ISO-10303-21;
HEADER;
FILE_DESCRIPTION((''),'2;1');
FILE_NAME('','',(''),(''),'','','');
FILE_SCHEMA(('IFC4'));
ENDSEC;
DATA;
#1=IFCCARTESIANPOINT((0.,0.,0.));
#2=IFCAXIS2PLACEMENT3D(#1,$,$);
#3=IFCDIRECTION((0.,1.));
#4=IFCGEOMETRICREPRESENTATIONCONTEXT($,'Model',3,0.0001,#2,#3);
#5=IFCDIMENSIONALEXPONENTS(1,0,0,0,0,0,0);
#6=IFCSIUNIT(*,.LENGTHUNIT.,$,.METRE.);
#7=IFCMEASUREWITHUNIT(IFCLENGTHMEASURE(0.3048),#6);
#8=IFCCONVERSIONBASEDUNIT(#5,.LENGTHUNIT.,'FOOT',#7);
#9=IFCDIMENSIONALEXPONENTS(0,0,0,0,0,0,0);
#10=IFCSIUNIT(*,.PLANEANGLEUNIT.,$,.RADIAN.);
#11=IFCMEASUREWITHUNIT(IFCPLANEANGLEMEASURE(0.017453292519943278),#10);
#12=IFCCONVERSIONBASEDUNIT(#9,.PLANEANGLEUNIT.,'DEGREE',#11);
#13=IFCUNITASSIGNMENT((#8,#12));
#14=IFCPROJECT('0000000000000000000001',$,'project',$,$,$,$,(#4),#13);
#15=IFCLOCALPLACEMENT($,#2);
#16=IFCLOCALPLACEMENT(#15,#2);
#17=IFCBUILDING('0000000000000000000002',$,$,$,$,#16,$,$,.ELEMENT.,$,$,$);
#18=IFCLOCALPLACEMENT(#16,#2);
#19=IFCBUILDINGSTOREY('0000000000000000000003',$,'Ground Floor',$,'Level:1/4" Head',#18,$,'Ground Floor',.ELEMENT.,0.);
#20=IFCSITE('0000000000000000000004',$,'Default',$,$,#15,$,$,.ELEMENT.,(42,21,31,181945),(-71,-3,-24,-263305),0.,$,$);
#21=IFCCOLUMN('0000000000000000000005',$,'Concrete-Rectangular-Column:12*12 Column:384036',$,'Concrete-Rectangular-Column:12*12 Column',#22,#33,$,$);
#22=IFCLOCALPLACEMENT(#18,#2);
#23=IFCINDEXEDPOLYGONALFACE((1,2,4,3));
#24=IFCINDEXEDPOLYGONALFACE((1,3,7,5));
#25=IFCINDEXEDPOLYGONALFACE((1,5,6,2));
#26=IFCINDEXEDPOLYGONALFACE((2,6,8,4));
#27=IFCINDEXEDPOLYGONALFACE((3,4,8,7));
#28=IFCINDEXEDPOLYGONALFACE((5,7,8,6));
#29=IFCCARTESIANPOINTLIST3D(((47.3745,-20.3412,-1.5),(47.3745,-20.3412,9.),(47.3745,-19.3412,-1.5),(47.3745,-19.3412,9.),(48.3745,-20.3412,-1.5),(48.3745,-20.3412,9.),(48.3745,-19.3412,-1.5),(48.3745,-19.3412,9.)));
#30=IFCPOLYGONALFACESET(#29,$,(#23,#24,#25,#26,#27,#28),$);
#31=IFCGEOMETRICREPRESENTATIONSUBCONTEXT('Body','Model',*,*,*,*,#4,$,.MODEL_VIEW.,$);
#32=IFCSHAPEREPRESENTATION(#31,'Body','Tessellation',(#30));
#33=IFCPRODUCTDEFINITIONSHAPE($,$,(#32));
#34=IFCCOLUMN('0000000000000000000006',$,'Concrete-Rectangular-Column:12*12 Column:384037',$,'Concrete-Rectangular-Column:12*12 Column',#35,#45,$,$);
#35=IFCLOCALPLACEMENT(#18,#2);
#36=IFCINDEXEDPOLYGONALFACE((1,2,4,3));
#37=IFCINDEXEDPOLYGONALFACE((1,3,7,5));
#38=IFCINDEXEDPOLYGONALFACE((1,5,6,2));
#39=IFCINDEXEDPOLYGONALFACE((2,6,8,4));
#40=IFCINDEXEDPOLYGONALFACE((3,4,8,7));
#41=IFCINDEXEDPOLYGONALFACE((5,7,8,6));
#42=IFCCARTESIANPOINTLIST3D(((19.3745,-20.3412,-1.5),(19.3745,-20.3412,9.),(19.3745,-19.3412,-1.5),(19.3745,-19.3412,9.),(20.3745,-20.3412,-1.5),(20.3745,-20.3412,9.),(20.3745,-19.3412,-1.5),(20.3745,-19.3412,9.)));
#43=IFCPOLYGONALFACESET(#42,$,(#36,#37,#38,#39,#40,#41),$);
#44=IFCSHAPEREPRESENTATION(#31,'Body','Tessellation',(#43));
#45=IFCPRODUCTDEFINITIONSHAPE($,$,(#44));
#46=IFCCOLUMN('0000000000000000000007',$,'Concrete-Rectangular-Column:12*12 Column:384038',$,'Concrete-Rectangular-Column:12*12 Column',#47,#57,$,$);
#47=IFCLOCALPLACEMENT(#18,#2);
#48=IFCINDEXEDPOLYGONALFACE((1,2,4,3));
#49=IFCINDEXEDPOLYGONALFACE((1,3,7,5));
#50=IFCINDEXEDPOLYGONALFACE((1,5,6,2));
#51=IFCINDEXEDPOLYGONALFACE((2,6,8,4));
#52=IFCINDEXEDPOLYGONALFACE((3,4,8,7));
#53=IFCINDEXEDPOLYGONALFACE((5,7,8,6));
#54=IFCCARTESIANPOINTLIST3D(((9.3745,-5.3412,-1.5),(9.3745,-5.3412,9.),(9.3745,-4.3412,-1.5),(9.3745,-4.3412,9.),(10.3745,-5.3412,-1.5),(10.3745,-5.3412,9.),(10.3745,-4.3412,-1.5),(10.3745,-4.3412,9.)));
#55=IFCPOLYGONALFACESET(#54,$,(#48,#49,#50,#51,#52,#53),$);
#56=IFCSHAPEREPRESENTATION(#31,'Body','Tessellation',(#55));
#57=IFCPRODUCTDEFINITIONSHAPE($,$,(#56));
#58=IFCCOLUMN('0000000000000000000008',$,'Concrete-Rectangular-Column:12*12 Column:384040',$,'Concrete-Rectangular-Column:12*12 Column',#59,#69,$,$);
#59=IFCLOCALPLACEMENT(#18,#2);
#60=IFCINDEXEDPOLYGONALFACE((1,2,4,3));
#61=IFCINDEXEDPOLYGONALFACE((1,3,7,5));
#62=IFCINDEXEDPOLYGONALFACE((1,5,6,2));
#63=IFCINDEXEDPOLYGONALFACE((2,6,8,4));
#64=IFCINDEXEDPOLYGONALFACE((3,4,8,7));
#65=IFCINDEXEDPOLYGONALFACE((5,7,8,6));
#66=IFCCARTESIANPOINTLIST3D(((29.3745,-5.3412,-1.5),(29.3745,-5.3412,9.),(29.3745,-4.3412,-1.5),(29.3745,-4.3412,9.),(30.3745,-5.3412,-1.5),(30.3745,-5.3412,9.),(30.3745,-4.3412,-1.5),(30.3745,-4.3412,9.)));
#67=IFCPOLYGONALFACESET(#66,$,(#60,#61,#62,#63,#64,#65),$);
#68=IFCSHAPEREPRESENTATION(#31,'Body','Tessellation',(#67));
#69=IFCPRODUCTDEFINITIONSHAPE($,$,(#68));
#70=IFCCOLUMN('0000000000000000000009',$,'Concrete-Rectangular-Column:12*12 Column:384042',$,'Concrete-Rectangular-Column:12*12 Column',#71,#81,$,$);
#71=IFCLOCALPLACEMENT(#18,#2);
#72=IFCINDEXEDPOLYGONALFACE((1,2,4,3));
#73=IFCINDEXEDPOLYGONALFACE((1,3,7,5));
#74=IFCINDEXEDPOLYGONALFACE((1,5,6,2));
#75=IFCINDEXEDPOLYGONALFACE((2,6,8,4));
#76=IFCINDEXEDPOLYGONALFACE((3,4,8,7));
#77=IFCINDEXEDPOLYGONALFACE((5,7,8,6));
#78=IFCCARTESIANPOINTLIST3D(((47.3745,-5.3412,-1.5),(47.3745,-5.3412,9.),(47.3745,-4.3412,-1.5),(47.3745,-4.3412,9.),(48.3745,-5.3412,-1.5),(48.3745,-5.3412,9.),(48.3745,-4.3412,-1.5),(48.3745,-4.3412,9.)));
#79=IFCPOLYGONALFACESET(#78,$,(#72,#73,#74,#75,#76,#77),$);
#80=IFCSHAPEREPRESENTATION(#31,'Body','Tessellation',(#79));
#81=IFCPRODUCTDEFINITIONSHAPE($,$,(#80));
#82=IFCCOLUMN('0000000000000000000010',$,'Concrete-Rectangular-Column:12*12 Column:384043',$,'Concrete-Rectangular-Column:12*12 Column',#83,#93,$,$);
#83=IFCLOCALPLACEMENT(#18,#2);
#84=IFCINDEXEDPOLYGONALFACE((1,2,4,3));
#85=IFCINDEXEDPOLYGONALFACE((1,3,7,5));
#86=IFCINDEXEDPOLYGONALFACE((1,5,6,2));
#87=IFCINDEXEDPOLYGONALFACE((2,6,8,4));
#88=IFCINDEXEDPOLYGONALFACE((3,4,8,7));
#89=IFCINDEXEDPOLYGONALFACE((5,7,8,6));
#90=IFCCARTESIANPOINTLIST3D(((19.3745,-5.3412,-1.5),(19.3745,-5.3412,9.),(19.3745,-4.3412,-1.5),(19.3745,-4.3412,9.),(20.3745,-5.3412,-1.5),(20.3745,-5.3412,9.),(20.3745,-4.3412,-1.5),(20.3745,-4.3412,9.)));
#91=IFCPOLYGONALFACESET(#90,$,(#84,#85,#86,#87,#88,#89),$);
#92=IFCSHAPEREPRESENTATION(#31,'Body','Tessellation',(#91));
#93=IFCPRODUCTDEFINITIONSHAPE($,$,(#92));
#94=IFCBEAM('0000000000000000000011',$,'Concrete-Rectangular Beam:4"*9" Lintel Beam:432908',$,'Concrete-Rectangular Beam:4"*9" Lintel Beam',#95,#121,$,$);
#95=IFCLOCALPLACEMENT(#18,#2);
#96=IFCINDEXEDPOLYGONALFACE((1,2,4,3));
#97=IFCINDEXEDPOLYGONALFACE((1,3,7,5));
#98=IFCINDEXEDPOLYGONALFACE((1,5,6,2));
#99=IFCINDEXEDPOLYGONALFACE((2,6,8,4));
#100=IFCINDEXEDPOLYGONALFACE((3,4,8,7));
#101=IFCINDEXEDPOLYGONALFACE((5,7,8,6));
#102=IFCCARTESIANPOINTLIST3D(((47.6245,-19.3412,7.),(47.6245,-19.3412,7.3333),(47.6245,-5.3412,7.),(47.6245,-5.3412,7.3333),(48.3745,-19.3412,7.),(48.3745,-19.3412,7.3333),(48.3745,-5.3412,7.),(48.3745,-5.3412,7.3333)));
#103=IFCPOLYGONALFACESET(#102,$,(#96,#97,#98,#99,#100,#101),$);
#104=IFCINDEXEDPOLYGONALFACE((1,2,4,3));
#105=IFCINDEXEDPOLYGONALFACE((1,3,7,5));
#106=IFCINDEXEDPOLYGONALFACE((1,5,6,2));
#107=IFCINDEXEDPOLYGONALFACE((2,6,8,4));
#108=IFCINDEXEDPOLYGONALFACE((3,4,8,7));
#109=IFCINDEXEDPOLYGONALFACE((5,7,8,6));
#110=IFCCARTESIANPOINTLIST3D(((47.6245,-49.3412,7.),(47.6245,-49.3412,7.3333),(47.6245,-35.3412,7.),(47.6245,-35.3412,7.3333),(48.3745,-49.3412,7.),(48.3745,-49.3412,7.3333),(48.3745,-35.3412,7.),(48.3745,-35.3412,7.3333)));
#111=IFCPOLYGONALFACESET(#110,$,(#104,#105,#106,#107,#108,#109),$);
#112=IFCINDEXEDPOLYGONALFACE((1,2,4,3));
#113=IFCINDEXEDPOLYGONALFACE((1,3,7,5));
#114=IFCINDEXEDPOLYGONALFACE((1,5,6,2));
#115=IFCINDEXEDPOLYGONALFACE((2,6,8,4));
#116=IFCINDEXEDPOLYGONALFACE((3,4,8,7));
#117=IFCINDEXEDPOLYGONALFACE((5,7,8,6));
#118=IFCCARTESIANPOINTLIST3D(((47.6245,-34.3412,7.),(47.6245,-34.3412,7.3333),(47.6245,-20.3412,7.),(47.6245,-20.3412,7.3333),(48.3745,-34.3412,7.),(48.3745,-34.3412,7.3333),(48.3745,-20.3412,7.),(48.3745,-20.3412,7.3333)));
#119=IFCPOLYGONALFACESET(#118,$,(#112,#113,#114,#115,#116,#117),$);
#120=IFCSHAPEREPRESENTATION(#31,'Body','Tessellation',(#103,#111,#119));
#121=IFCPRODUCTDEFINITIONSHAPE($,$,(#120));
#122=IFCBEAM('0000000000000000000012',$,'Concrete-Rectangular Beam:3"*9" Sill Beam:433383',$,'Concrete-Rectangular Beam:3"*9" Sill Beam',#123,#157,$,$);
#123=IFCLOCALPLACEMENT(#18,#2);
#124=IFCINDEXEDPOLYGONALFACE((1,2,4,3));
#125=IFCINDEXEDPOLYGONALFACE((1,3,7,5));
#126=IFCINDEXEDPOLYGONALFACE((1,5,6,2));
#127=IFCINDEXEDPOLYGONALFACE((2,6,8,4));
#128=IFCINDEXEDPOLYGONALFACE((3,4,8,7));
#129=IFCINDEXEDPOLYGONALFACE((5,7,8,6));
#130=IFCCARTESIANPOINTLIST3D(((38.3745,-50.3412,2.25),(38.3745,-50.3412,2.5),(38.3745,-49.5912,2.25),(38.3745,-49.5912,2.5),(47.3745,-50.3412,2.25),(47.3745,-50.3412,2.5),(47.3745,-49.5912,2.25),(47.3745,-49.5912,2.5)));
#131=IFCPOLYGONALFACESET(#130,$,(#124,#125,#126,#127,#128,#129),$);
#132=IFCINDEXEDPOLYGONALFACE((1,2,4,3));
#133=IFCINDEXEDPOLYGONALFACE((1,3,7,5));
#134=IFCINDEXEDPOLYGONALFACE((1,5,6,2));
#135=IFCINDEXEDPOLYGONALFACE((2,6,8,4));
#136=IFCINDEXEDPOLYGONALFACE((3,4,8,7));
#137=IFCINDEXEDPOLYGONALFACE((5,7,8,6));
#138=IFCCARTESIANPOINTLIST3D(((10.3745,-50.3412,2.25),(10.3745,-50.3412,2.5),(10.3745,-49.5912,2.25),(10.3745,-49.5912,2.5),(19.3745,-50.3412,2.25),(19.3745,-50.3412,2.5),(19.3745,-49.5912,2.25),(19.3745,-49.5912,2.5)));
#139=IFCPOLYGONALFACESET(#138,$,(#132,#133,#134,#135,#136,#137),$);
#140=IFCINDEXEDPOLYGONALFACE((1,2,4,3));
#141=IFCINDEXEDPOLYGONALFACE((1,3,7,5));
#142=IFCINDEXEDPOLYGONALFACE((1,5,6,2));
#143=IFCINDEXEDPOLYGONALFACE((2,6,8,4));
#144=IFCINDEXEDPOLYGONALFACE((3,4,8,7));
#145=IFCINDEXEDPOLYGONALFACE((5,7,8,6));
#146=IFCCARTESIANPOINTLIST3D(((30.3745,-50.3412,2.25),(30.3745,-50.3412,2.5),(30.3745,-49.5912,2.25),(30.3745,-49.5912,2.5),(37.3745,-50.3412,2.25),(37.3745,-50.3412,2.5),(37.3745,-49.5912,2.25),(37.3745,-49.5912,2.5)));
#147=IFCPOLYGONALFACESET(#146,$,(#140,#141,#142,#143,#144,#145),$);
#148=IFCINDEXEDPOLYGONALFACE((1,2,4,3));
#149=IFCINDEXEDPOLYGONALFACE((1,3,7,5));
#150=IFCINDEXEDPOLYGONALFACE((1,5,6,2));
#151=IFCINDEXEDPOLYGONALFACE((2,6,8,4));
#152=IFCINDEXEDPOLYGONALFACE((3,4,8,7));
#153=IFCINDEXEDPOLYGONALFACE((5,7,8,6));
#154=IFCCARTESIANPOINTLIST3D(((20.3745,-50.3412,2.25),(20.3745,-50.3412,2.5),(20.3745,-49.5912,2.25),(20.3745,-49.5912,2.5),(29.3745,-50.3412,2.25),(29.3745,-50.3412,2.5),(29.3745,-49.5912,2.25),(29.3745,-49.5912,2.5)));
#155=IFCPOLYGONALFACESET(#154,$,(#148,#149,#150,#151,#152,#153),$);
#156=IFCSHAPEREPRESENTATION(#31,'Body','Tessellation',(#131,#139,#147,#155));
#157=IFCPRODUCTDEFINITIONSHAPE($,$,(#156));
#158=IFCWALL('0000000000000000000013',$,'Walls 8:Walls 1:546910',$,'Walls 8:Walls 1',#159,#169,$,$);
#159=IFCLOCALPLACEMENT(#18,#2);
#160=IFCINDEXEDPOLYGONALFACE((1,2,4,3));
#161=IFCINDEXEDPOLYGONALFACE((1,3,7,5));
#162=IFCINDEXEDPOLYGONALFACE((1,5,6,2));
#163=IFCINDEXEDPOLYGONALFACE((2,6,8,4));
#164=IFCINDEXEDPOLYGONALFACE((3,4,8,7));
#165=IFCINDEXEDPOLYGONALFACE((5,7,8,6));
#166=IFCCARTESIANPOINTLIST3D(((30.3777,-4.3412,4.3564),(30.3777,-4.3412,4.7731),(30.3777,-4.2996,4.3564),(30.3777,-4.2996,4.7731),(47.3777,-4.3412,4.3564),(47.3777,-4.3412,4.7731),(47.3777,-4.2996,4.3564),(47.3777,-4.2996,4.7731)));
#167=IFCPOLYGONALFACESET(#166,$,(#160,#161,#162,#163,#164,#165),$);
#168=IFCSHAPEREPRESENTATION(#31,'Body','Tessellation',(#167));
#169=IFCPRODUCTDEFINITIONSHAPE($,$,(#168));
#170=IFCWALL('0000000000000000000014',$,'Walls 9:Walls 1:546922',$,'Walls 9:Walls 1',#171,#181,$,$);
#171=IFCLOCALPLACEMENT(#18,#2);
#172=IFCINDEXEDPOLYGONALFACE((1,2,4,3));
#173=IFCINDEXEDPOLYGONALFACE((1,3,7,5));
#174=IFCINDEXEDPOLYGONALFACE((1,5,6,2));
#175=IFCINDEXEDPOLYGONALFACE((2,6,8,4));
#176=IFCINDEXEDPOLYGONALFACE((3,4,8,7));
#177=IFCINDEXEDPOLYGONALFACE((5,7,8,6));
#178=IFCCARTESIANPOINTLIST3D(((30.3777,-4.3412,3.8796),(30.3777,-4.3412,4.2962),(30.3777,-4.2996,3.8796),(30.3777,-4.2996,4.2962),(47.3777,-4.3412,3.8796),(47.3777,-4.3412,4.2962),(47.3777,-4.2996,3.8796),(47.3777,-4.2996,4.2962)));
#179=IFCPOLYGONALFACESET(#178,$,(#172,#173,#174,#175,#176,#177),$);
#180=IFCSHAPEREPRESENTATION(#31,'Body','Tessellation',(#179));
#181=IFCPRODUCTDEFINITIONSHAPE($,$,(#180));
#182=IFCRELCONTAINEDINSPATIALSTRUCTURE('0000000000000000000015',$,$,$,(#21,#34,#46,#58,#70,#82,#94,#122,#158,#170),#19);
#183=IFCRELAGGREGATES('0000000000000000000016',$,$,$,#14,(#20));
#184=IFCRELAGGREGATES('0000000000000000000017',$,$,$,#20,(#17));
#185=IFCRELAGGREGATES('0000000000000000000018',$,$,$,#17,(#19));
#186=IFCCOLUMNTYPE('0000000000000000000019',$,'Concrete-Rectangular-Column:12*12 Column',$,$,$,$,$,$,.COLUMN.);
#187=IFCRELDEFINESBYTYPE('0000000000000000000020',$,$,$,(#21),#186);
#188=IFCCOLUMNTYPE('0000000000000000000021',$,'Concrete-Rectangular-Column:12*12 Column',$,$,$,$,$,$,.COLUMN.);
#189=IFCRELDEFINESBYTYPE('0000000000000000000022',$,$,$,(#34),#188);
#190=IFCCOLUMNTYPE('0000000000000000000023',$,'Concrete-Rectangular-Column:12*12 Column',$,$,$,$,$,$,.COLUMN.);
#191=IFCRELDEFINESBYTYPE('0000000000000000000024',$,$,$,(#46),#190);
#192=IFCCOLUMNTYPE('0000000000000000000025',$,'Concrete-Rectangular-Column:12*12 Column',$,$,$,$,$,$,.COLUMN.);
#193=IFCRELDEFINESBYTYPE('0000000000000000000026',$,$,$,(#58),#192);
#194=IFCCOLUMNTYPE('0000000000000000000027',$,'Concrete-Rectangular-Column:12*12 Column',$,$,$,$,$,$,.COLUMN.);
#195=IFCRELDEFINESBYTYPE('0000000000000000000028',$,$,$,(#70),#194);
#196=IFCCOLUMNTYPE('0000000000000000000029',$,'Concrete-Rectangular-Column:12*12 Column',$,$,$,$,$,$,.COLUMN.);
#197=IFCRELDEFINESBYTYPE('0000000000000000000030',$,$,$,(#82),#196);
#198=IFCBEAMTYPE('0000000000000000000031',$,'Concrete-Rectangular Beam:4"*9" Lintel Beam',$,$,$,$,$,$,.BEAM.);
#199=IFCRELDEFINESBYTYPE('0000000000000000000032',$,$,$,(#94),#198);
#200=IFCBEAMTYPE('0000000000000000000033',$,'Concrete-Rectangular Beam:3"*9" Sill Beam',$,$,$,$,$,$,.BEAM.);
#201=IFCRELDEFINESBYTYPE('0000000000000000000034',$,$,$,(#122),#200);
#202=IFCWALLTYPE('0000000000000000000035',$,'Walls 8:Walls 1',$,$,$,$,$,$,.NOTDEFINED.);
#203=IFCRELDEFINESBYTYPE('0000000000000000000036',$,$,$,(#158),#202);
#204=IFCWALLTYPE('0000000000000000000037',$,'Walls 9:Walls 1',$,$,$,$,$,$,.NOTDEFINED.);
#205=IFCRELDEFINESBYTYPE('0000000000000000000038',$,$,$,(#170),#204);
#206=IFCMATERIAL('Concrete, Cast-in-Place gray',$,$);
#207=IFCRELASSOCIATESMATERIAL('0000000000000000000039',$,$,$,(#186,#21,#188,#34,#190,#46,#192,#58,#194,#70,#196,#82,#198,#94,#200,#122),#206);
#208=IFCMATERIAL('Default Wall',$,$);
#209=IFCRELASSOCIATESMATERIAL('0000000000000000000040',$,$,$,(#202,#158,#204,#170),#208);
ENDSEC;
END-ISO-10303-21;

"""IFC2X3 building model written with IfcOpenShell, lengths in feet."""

from ifc_helpers import new_model, entity, si_unit, converted_unit, direction, frame, frame_2d, origin, origin_2d_with_axis, place, context, subcontext, project, spatial, rectangle, extrude, source, transform, mapped, material, type_object, type_shapes, element, save


model = new_model("IFC2X3")

# Units and contexts
model_context = context("Model", 3, precision=0.0001, world=origin(), true_north=direction((0.0, 1.0)))
body_context = subcontext(model_context, "Body", "Model", "MODEL_VIEW")
ifc_project = project(units=[converted_unit("LENGTHUNIT", "FOOT", entity("IfcLengthMeasure", 0.3048), si_unit("LENGTHUNIT", "METRE"), dimensions=[1, 0, 0, 0, 0, 0, 0]), converted_unit("PLANEANGLEUNIT", "DEGREE", entity("IfcPlaneAngleMeasure", 0.017453292519943278), si_unit("PLANEANGLEUNIT", "RADIAN"), dimensions=[0, 0, 0, 0, 0, 0, 0])], contexts=[model_context])

# Site, building, storey
site_placement = place(None, origin())
site = spatial("IfcSite", under=ifc_project, at=site_placement, Name="Default", CompositionType="ELEMENT", RefLatitude=(42, 21, 31, 181945), RefLongitude=(-71, -3, -24, -263305), RefElevation=0.0)
building_placement = place(site_placement, origin())
building = spatial("IfcBuilding", under=site, at=building_placement, CompositionType="ELEMENT")
storey_placement = place(building_placement, origin())
storey = spatial("IfcBuildingStorey", under=building, at=storey_placement, Name="Ground Floor", ObjectType="Level:1/4\" Head", LongName="Ground Floor", CompositionType="ELEMENT", Elevation=0.0)

# Columns
ifc_material_1 = material(Name="Concrete, Cast-in-Place gray")
column_type_1 = type_object("IfcColumnType", Name="Concrete-Rectangular-Column:12*12 Column", PredefinedType="COLUMN", material=ifc_material_1)
shared_shape_1 = source(origin(), body_context, "Body", "SweptSolid", [
    extrude(rectangle(XDim=1.0, YDim=1.0, at=frame_2d((0.0, 0.0), x_axis=(1.0, 0.0))), frame((47.8745, -19.8412, -1.5), z_axis=(0.0, 0.0, 1.0), x_axis=(-1.0, 0.0, 0.0)), (0.0, 0.0, 1.0), 10.5),
])
type_shapes(column_type_1, [shared_shape_1])
column_1_placement = place(storey_placement, origin())
element("IfcColumn", 1, at=column_1_placement, inside=storey, type_object=column_type_1, material=ifc_material_1, Name="Concrete-Rectangular-Column:12*12 Column:384036", ObjectType="Concrete-Rectangular-Column:12*12 Column", context=body_context, shape_type="MappedRepresentation", body=[
    mapped(shared_shape_1, transform((0.0, 0.0, 0.0), scale=1.0)),
])
column_type_2 = type_object("IfcColumnType", Name="Concrete-Rectangular-Column:12*12 Column", PredefinedType="COLUMN", material=ifc_material_1)
shared_shape_2 = source(origin(), body_context, "Body", "SweptSolid", [
    extrude(rectangle(XDim=1.0, YDim=1.0, at=frame_2d((0.0, 0.0), x_axis=(1.0, 0.0))), frame((19.8745, -19.8412, -1.5), z_axis=(0.0, 0.0, 1.0), x_axis=(-1.0, 0.0, 0.0)), (0.0, 0.0, 1.0), 10.5),
])
type_shapes(column_type_2, [shared_shape_2])
column_2_placement = place(storey_placement, origin())
element("IfcColumn", 2, at=column_2_placement, inside=storey, type_object=column_type_2, material=ifc_material_1, Name="Concrete-Rectangular-Column:12*12 Column:384037", ObjectType="Concrete-Rectangular-Column:12*12 Column", context=body_context, shape_type="MappedRepresentation", body=[
    mapped(shared_shape_2, transform((0.0, 0.0, 0.0), scale=1.0)),
])
column_type_3 = type_object("IfcColumnType", Name="Concrete-Rectangular-Column:12*12 Column", PredefinedType="COLUMN", material=ifc_material_1)
shared_shape_3 = source(origin(), body_context, "Body", "SweptSolid", [
    extrude(rectangle(XDim=1.0, YDim=1.0, at=origin_2d_with_axis()), frame((9.8745, -4.8412, -1.5), z_axis=(0.0, 0.0, 1.0), x_axis=(-1.0, 0.0, 0.0)), (0.0, 0.0, 1.0), 10.5),
])
type_shapes(column_type_3, [shared_shape_3])
column_3_placement = place(storey_placement, origin())
element("IfcColumn", 3, at=column_3_placement, inside=storey, type_object=column_type_3, material=ifc_material_1, Name="Concrete-Rectangular-Column:12*12 Column:384038", ObjectType="Concrete-Rectangular-Column:12*12 Column", context=body_context, shape_type="MappedRepresentation", body=[
    mapped(shared_shape_3, transform((0.0, 0.0, 0.0), scale=1.0)),
])
column_type_4 = type_object("IfcColumnType", Name="Concrete-Rectangular-Column:12*12 Column", PredefinedType="COLUMN", material=ifc_material_1)
shared_shape_4 = source(origin(), body_context, "Body", "SweptSolid", [
    extrude(rectangle(XDim=1.0, YDim=1.0, at=frame_2d((0.0, 0.0), x_axis=(1.0, 0.0))), frame((29.8745, -4.8412, -1.5), z_axis=(0.0, 0.0, 1.0), x_axis=(-1.0, 0.0, 0.0)), (0.0, 0.0, 1.0), 10.5),
])
type_shapes(column_type_4, [shared_shape_4])
column_4_placement = place(storey_placement, origin())
element("IfcColumn", 4, at=column_4_placement, inside=storey, type_object=column_type_4, material=ifc_material_1, Name="Concrete-Rectangular-Column:12*12 Column:384040", ObjectType="Concrete-Rectangular-Column:12*12 Column", context=body_context, shape_type="MappedRepresentation", body=[
    mapped(shared_shape_4, transform((0.0, 0.0, 0.0), scale=1.0)),
])
column_type_5 = type_object("IfcColumnType", Name="Concrete-Rectangular-Column:12*12 Column", PredefinedType="COLUMN", material=ifc_material_1)
shared_shape_5 = source(origin(), body_context, "Body", "SweptSolid", [
    extrude(rectangle(XDim=1.0, YDim=1.0, at=frame_2d((0.0, 0.0), x_axis=(1.0, 0.0))), frame((47.8745, -4.8412, -1.5), z_axis=(0.0, 0.0, 1.0), x_axis=(-1.0, 0.0, 0.0)), (0.0, 0.0, 1.0), 10.5),
])
type_shapes(column_type_5, [shared_shape_5])
column_5_placement = place(storey_placement, origin())
element("IfcColumn", 5, at=column_5_placement, inside=storey, type_object=column_type_5, material=ifc_material_1, Name="Concrete-Rectangular-Column:12*12 Column:384042", ObjectType="Concrete-Rectangular-Column:12*12 Column", context=body_context, shape_type="MappedRepresentation", body=[
    mapped(shared_shape_5, transform((0.0, 0.0, 0.0), scale=1.0)),
])
column_type_6 = type_object("IfcColumnType", Name="Concrete-Rectangular-Column:12*12 Column", PredefinedType="COLUMN", material=ifc_material_1)
shared_shape_6 = source(origin(), body_context, "Body", "SweptSolid", [
    extrude(rectangle(XDim=1.0, YDim=1.0, at=frame_2d((0.0, 0.0), x_axis=(1.0, 0.0))), frame((19.8745, -4.8412, -1.5), z_axis=(0.0, 0.0, 1.0), x_axis=(-1.0, 0.0, 0.0)), (0.0, 0.0, 1.0), 10.5),
])
type_shapes(column_type_6, [shared_shape_6])
column_6_placement = place(storey_placement, origin())
element("IfcColumn", 6, at=column_6_placement, inside=storey, type_object=column_type_6, material=ifc_material_1, Name="Concrete-Rectangular-Column:12*12 Column:384043", ObjectType="Concrete-Rectangular-Column:12*12 Column", context=body_context, shape_type="MappedRepresentation", body=[
    mapped(shared_shape_6, transform((0.0, 0.0, 0.0), scale=1.0)),
])

# Beams
beam_type_1 = type_object("IfcBeamType", Name="Concrete-Rectangular Beam:4\"*9\" Lintel Beam", PredefinedType="BEAM", material=ifc_material_1)
shared_shape_7 = source(origin(), body_context, "Body", "SweptSolid", [
    extrude(rectangle(XDim=0.3333, YDim=0.75, at=frame_2d((0.0, 0.0), x_axis=(0.0, 1.0))), frame((47.9995, -19.3412, 7.1667), z_axis=(0.0, 1.0, 0.0), x_axis=(-1.0, 0.0, 0.0)), (0.0, 0.0, 1.0), 14.0),
    extrude(rectangle(XDim=0.3333, YDim=0.75, at=frame_2d((0.0, 0.0), x_axis=(0.0, 1.0))), frame((47.9995, -49.3412, 7.1667), z_axis=(0.0, 1.0, 0.0), x_axis=(-1.0, 0.0, 0.0)), (0.0, 0.0, 1.0), 14.0),
    extrude(rectangle(XDim=0.3333, YDim=0.75, at=frame_2d((0.0, 0.0), x_axis=(0.0, 1.0))), frame((47.9995, -34.3412, 7.1667), z_axis=(0.0, 1.0, 0.0), x_axis=(-1.0, 0.0, 0.0)), (0.0, 0.0, 1.0), 14.0),
])
type_shapes(beam_type_1, [shared_shape_7])
beam_1_placement = place(storey_placement, origin())
element("IfcBeam", 7, at=beam_1_placement, inside=storey, type_object=beam_type_1, material=ifc_material_1, Name="Concrete-Rectangular Beam:4\"*9\" Lintel Beam:432908", ObjectType="Concrete-Rectangular Beam:4\"*9\" Lintel Beam", context=body_context, shape_type="MappedRepresentation", body=[
    mapped(shared_shape_7, transform((0.0, 0.0, 0.0), scale=1.0)),
])
beam_type_2 = type_object("IfcBeamType", Name="Concrete-Rectangular Beam:3\"*9\" Sill Beam", PredefinedType="BEAM", material=ifc_material_1)
shared_shape_8 = source(origin(), body_context, "Body", "SweptSolid", [
    extrude(rectangle(XDim=0.25, YDim=0.75, at=frame_2d((0.0, 0.0), x_axis=(1.0, 0.0))), frame((38.3745, -49.9662, 2.375), z_axis=(1.0, 0.0, 0.0), x_axis=(0.0, 0.0, -1.0)), (0.0, 0.0, 1.0), 9.0),
    extrude(rectangle(XDim=0.25, YDim=0.75, at=frame_2d((0.0, 0.0), x_axis=(1.0, 0.0))), frame((10.3745, -49.9662, 2.375), z_axis=(1.0, 0.0, 0.0), x_axis=(0.0, 0.0, -1.0)), (0.0, 0.0, 1.0), 9.0),
    extrude(rectangle(XDim=0.25, YDim=0.75, at=frame_2d((0.0, 0.0), x_axis=(1.0, 0.0))), frame((30.3745, -49.9662, 2.375), z_axis=(1.0, 0.0, 0.0), x_axis=(0.0, 0.0, -1.0)), (0.0, 0.0, 1.0), 7.0),
    extrude(rectangle(XDim=0.25, YDim=0.75, at=frame_2d((0.0, 0.0), x_axis=(1.0, 0.0))), frame((20.3745, -49.9662, 2.375), z_axis=(1.0, 0.0, 0.0), x_axis=(0.0, 0.0, -1.0)), (0.0, 0.0, 1.0), 9.0),
])
type_shapes(beam_type_2, [shared_shape_8])
beam_2_placement = place(storey_placement, origin())
element("IfcBeam", 8, at=beam_2_placement, inside=storey, type_object=beam_type_2, material=ifc_material_1, Name="Concrete-Rectangular Beam:3\"*9\" Sill Beam:433383", ObjectType="Concrete-Rectangular Beam:3\"*9\" Sill Beam", context=body_context, shape_type="MappedRepresentation", body=[
    mapped(shared_shape_8, transform((0.0, 0.0, 0.0), scale=1.0)),
])

# Walls
ifc_material_2 = material(Name="Default Wall")
wall_type_1 = type_object("IfcWallType", Name="Walls 8:Walls 1", PredefinedType="NOTDEFINED", material=ifc_material_2)
wall_1_placement = place(storey_placement, frame((30.3777, -4.3412, 4.3564)))
element("IfcWall", 9, at=wall_1_placement, inside=storey, type_object=wall_type_1, material=ifc_material_2, Name="Walls 8:Walls 1:546910", ObjectType="Walls 8:Walls 1", context=body_context, shape_type="SweptSolid", body=[
    extrude(rectangle(XDim=0.0417, YDim=17.0, at=frame_2d((0.0, 0.0), x_axis=(1.0, 0.0))), frame((8.5, 0.0208, 0.0), z_axis=(0.0, 0.0, 1.0), x_axis=(0.0, -1.0, 0.0)), (0.0, 0.0, 1.0), 0.4167),
])
wall_type_2 = type_object("IfcWallType", Name="Walls 9:Walls 1", PredefinedType="NOTDEFINED", material=ifc_material_2)
wall_2_placement = place(storey_placement, frame((30.3777, -4.3412, 3.8796)))
element("IfcWall", 10, at=wall_2_placement, inside=storey, type_object=wall_type_2, material=ifc_material_2, Name="Walls 9:Walls 1:546922", ObjectType="Walls 9:Walls 1", context=body_context, shape_type="SweptSolid", body=[
    extrude(rectangle(XDim=0.0417, YDim=17.0, at=frame_2d((0.0, 0.0), x_axis=(1.0, 0.0))), frame((8.5, 0.0208, 0.0), z_axis=(0.0, 0.0, 1.0), x_axis=(0.0, -1.0, 0.0)), (0.0, 0.0, 1.0), 0.4167),
])

save(model, "model.ifc")
